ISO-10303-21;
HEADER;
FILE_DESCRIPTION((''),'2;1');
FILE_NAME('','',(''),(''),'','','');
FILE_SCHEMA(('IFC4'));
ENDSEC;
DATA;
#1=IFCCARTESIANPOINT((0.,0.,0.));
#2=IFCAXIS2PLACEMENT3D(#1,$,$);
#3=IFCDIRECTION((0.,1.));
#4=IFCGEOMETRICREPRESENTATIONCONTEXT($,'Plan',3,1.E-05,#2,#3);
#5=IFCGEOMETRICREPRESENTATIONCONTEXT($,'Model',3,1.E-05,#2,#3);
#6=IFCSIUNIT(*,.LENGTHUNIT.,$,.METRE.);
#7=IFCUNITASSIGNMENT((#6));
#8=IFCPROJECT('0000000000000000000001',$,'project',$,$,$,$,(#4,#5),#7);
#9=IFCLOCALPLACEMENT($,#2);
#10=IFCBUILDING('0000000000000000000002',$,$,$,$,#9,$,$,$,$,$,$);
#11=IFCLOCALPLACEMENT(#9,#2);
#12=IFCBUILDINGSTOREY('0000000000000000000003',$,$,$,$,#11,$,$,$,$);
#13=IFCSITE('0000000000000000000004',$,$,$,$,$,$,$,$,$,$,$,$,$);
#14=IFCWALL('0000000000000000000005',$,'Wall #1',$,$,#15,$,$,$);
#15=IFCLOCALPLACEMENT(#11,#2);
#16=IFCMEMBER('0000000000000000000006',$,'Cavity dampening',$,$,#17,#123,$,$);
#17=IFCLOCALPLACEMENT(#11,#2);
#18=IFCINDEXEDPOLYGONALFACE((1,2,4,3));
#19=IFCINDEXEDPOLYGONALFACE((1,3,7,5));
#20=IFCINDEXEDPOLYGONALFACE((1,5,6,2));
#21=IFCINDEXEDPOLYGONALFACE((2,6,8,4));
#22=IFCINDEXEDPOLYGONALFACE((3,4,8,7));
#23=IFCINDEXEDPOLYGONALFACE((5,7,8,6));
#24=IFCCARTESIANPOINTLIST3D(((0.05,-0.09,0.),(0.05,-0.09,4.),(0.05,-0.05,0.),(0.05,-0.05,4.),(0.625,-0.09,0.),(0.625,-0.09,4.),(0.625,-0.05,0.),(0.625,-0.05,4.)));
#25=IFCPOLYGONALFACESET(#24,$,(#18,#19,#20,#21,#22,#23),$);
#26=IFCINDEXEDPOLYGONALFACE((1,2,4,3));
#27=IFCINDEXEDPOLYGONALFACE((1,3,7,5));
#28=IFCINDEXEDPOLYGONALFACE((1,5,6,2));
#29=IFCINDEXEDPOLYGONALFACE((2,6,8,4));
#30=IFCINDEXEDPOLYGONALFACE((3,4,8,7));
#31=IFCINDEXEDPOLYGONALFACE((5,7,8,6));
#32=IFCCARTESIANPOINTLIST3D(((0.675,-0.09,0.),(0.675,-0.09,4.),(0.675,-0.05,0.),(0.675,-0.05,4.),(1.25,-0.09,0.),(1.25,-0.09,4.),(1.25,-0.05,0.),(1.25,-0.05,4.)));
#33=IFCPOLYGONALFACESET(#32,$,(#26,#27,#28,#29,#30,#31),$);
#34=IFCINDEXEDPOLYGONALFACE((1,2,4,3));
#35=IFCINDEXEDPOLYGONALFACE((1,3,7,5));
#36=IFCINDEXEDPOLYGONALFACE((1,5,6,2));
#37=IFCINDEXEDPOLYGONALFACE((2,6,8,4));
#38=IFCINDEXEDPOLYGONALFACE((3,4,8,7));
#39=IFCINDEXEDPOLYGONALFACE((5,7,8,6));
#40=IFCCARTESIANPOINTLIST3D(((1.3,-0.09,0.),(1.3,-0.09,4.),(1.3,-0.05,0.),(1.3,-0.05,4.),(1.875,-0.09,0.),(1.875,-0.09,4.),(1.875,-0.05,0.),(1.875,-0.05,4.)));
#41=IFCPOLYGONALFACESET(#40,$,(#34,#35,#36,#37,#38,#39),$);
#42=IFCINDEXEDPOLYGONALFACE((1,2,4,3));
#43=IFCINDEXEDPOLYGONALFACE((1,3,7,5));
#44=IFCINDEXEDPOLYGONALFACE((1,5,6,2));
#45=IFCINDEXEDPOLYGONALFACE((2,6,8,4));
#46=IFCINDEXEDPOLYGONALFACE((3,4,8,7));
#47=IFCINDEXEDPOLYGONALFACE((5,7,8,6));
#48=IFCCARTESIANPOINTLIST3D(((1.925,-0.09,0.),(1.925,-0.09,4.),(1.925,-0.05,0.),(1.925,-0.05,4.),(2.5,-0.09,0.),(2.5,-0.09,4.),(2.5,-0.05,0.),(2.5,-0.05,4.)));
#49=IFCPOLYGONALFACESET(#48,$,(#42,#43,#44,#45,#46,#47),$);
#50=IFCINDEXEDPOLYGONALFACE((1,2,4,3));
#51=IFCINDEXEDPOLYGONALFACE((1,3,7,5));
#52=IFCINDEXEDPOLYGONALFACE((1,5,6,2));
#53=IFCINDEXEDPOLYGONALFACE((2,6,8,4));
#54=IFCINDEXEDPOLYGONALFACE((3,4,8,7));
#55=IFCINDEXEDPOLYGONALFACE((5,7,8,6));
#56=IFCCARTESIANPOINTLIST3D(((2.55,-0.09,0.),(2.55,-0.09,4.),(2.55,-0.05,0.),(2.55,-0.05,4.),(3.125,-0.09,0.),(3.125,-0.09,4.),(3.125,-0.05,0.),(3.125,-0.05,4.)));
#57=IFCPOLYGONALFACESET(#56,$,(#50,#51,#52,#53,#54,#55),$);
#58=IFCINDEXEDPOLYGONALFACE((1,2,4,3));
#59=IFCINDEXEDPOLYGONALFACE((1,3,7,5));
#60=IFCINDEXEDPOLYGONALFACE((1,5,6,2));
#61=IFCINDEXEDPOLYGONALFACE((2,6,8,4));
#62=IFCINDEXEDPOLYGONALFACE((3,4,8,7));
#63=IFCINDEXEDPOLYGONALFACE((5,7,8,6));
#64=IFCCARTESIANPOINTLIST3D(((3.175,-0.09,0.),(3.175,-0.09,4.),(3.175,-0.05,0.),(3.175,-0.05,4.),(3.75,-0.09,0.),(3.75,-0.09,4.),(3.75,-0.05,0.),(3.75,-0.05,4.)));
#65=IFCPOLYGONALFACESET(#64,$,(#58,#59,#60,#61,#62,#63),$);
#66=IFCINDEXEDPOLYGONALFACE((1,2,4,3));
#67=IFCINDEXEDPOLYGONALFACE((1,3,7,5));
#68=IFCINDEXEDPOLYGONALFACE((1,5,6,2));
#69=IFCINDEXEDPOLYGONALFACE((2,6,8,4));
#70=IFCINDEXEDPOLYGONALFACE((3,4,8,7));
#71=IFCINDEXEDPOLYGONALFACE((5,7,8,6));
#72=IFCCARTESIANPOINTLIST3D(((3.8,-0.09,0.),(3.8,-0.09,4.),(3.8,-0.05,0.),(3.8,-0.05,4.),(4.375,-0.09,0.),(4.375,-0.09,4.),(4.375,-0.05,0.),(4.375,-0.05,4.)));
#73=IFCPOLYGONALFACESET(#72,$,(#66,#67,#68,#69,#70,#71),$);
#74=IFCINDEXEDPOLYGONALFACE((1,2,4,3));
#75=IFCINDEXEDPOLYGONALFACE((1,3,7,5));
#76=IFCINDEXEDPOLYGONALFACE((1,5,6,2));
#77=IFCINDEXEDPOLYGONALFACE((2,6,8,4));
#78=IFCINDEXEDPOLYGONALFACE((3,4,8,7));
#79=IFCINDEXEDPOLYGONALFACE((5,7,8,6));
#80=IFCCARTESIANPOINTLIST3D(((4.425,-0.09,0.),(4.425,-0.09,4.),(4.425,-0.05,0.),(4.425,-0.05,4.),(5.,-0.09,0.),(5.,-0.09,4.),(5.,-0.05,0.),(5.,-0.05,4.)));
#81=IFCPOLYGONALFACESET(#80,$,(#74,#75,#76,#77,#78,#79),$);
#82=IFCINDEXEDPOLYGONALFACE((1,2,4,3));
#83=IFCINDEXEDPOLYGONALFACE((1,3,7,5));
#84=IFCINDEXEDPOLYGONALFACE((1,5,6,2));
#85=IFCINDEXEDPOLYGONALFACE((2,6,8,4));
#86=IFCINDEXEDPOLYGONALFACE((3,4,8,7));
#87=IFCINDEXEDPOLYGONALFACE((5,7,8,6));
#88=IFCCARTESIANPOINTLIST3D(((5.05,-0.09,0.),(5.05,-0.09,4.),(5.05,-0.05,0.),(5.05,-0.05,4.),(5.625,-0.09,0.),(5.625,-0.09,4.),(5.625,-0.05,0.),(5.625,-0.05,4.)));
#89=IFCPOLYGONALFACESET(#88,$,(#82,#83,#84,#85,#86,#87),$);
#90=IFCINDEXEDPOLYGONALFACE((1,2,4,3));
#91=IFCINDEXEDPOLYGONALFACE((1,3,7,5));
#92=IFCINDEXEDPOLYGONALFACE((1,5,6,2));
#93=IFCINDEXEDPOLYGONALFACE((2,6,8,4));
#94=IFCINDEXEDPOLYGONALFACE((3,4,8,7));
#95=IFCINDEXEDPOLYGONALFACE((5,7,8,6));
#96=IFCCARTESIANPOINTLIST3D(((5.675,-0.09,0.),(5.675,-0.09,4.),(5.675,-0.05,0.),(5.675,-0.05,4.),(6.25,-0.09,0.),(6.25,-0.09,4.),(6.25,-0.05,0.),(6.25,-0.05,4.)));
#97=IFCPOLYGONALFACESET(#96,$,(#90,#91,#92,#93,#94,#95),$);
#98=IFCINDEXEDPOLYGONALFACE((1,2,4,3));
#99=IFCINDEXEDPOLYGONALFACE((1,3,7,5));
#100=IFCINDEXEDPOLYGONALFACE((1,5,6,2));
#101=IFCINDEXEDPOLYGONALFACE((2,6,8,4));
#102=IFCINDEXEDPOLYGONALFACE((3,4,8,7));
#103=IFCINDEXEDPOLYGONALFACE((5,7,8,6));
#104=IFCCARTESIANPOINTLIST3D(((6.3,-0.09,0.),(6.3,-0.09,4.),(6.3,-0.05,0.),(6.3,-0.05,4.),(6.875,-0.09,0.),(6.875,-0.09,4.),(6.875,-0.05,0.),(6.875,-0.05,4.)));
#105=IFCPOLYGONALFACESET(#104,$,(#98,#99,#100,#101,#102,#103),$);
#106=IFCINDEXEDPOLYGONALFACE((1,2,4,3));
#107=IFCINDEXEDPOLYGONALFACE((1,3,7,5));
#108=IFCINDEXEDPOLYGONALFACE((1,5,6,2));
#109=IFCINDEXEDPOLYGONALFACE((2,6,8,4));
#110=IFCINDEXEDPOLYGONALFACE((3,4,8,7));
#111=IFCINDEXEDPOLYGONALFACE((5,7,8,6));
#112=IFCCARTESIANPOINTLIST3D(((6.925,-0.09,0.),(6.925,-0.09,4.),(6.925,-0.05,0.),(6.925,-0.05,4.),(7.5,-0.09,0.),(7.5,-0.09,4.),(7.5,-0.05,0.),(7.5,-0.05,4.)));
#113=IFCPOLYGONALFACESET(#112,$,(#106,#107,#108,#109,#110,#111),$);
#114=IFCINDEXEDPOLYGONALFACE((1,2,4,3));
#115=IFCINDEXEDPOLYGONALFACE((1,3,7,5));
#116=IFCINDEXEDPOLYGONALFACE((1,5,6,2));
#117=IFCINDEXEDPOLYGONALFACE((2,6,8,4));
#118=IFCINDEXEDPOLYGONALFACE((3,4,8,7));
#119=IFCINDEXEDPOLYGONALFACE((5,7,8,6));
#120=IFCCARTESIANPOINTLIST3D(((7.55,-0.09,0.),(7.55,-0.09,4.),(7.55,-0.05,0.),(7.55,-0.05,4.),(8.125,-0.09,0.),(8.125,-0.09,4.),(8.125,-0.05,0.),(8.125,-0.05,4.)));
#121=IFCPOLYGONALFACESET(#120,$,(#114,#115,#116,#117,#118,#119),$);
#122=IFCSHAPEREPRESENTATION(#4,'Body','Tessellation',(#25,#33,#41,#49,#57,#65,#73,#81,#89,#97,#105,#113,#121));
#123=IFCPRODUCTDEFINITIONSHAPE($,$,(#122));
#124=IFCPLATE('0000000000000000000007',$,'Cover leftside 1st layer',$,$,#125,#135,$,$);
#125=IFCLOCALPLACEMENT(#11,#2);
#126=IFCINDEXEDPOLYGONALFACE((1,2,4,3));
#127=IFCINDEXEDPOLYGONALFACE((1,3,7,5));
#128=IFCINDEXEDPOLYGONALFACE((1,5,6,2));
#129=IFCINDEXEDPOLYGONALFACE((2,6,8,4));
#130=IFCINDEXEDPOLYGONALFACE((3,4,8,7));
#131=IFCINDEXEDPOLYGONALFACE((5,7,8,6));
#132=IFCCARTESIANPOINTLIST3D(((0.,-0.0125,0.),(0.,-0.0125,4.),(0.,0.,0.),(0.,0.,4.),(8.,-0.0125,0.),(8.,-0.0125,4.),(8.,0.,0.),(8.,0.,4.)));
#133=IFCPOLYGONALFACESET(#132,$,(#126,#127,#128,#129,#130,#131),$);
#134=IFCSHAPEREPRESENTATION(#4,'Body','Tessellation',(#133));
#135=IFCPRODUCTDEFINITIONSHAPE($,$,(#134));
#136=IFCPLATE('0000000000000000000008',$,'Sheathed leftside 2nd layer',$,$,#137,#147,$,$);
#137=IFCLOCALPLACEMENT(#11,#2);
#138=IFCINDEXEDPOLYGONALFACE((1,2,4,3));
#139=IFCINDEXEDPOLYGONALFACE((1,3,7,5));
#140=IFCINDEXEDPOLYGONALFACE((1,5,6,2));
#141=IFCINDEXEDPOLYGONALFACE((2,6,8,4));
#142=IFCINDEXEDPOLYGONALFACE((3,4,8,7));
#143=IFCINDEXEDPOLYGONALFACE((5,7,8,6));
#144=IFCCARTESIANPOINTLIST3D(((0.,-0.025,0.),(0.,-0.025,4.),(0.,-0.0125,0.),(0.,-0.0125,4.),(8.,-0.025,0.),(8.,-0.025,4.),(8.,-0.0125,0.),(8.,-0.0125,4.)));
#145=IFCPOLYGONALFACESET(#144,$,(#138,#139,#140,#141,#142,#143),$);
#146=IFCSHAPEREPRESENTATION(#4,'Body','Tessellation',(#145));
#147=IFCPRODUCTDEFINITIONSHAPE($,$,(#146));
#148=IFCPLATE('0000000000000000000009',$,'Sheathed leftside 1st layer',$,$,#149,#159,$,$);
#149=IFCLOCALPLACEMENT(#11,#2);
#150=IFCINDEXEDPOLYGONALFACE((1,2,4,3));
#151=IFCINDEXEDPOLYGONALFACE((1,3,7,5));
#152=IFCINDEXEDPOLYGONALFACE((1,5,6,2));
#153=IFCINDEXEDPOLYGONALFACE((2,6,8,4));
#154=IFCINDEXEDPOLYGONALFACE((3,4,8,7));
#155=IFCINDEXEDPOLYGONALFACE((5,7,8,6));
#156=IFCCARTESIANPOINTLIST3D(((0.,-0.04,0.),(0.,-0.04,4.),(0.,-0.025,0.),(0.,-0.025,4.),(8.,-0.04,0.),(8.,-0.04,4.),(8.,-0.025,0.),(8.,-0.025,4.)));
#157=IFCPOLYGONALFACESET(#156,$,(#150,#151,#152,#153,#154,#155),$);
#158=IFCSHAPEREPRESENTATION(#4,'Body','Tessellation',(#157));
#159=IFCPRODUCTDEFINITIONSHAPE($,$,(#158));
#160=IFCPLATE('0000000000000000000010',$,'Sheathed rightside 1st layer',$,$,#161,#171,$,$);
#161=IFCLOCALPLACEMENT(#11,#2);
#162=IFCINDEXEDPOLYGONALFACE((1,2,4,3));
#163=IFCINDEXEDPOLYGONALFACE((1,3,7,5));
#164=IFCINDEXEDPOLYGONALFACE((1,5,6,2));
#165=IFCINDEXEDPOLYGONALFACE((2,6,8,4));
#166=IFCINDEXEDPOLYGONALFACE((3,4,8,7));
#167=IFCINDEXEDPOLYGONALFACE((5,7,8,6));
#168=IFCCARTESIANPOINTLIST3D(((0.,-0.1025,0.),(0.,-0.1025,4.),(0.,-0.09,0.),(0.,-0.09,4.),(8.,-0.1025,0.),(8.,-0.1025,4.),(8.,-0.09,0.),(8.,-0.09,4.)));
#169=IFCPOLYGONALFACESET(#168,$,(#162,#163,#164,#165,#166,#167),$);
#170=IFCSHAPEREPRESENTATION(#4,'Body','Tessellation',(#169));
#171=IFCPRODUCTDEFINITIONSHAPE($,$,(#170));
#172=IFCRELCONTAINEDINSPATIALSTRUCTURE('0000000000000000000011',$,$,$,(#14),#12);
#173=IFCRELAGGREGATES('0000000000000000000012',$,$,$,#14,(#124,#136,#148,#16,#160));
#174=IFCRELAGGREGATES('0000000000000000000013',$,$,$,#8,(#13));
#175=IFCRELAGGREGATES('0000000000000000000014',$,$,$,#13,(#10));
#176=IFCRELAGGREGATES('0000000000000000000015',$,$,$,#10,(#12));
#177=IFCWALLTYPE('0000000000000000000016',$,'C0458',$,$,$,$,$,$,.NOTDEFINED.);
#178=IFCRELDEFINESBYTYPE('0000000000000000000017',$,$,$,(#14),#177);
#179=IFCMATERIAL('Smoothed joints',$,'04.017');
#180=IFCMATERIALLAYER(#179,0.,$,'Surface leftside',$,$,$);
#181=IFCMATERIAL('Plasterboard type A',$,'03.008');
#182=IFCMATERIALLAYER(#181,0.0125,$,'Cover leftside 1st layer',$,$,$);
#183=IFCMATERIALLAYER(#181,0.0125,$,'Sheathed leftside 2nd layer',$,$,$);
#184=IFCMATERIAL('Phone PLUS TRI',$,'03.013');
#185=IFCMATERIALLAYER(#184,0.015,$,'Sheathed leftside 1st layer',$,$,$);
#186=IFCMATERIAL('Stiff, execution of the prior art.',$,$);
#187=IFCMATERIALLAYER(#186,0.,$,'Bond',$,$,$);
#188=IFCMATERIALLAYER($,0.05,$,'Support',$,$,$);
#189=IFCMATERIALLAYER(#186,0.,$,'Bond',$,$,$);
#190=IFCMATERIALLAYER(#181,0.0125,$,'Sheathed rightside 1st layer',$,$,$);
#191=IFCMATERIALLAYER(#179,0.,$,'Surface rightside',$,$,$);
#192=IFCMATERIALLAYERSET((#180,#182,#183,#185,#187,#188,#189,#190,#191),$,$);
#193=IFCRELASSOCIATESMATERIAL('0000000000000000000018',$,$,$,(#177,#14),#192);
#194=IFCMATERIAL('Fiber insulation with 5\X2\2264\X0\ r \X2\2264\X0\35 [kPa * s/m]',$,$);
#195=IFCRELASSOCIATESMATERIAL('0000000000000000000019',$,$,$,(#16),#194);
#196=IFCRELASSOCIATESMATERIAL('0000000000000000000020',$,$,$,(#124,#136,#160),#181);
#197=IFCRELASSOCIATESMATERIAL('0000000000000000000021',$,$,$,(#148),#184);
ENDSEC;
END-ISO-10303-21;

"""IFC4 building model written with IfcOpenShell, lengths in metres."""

from ifc_helpers import new_model, si_unit, direction, frame, frame_2d, origin, origin_with_axes, place, context, project, spatial, rectangle, extrude, material, layer, layer_set, type_object, element, aggregate, save


model = new_model("IFC4")

# Units and contexts
plan_context = context("Plan", 3, precision=1e-05, world=origin(), true_north=direction((0.0, 1.0)))
model_context = context("Model", 3, precision=1e-05, world=origin(), true_north=direction((0.0, 1.0)))
ifc_project = project(units=[si_unit("LENGTHUNIT", "METRE")], contexts=[plan_context, model_context])

# Site, building, storey
site = spatial("IfcSite", under=ifc_project)
building_placement = place(None, origin())
building = spatial("IfcBuilding", under=site, at=building_placement)
storey_placement = place(building_placement, origin())
storey = spatial("IfcBuildingStorey", under=building, at=storey_placement)

# Wall, member, plates
ifc_material_1 = material(Name="Smoothed joints", Category="04.017")
ifc_layer_1 = layer(ifc_material_1, 0.0, Name="Surface leftside")
ifc_material_2 = material(Name="Plasterboard type A", Category="03.008")
ifc_layer_2 = layer(ifc_material_2, 0.0125, Name="Cover leftside 1st layer")
ifc_layer_3 = layer(ifc_material_2, 0.0125, Name="Sheathed leftside 2nd layer")
ifc_material_3 = material(Name="Phone PLUS TRI", Category="03.013")
ifc_layer_4 = layer(ifc_material_3, 0.015, Name="Sheathed leftside 1st layer")
ifc_material_4 = material(Name="Stiff, execution of the prior art.")
ifc_layer_5 = layer(ifc_material_4, 0.0, Name="Bond")
ifc_layer_6 = layer(None, 0.05, Name="Support")
ifc_layer_7 = layer(ifc_material_4, 0.0, Name="Bond")
ifc_layer_8 = layer(ifc_material_2, 0.0125, Name="Sheathed rightside 1st layer")
ifc_layer_9 = layer(ifc_material_1, 0.0, Name="Surface rightside")
ifc_layer_set = layer_set([ifc_layer_1, ifc_layer_2, ifc_layer_3, ifc_layer_4, ifc_layer_5, ifc_layer_6, ifc_layer_7, ifc_layer_8, ifc_layer_9])
wall_type = type_object("IfcWallType", Name="C0458", PredefinedType="NOTDEFINED", material=ifc_layer_set)
wall_placement = place(None, frame((0.0, 0.0, 0.0), z_axis=(0.0, -1.0, 0.0), x_axis=(1.0, 0.0, 0.0)))
wall = element("IfcWall", 1, at=wall_placement, inside=storey, type_object=wall_type, material=ifc_layer_set, Name="Wall #1")
ifc_material_5 = material(Name="Fiber insulation with 5≤ r ≤35 [kPa * s/m]")
member_1_placement = place(wall_placement, origin())
member_1 = element("IfcMember", 2, at=member_1_placement, material=ifc_material_5, Name="Cavity dampening", context=plan_context, shape_type="SweptSolid", body=[
    extrude(rectangle(XDim=0.575, YDim=0.04, at=frame_2d((0.2875, 0.02), x_axis=(1.0, 0.0))), frame((0.05, 4.0, 0.05), z_axis=(0.0, -1.0, 0.0), x_axis=(1.0, 0.0, 0.0)), (0.0, 0.0, 1.0), 4.0),
    extrude(rectangle(XDim=0.575, YDim=0.04, at=frame_2d((0.2875, 0.02), x_axis=(1.0, 0.0))), frame((0.675, 4.0, 0.05), z_axis=(0.0, -1.0, 0.0), x_axis=(1.0, 0.0, 0.0)), (0.0, 0.0, 1.0), 4.0),
    extrude(rectangle(XDim=0.575, YDim=0.04, at=frame_2d((0.2875, 0.02), x_axis=(1.0, 0.0))), frame((1.3, 4.0, 0.05), z_axis=(0.0, -1.0, 0.0), x_axis=(1.0, 0.0, 0.0)), (0.0, 0.0, 1.0), 4.0),
    extrude(rectangle(XDim=0.575, YDim=0.04, at=frame_2d((0.2875, 0.02), x_axis=(1.0, 0.0))), frame((1.925, 4.0, 0.05), z_axis=(0.0, -1.0, 0.0), x_axis=(1.0, 0.0, 0.0)), (0.0, 0.0, 1.0), 4.0),
    extrude(rectangle(XDim=0.575, YDim=0.04, at=frame_2d((0.2875, 0.02), x_axis=(1.0, 0.0))), frame((2.55, 4.0, 0.05), z_axis=(0.0, -1.0, 0.0), x_axis=(1.0, 0.0, 0.0)), (0.0, 0.0, 1.0), 4.0),
    extrude(rectangle(XDim=0.575, YDim=0.04, at=frame_2d((0.2875, 0.02), x_axis=(1.0, 0.0))), frame((3.175, 4.0, 0.05), z_axis=(0.0, -1.0, 0.0), x_axis=(1.0, 0.0, 0.0)), (0.0, 0.0, 1.0), 4.0),
    extrude(rectangle(XDim=0.575, YDim=0.04, at=frame_2d((0.2875, 0.02), x_axis=(1.0, 0.0))), frame((3.8, 4.0, 0.05), z_axis=(0.0, -1.0, 0.0), x_axis=(1.0, 0.0, 0.0)), (0.0, 0.0, 1.0), 4.0),
    extrude(rectangle(XDim=0.575, YDim=0.04, at=frame_2d((0.2875, 0.02), x_axis=(1.0, 0.0))), frame((4.425, 4.0, 0.05), z_axis=(0.0, -1.0, 0.0), x_axis=(1.0, 0.0, 0.0)), (0.0, 0.0, 1.0), 4.0),
    extrude(rectangle(XDim=0.575, YDim=0.04, at=frame_2d((0.2875, 0.02), x_axis=(1.0, 0.0))), frame((5.05, 4.0, 0.05), z_axis=(0.0, -1.0, 0.0), x_axis=(1.0, 0.0, 0.0)), (0.0, 0.0, 1.0), 4.0),
    extrude(rectangle(XDim=0.575, YDim=0.04, at=frame_2d((0.2875, 0.02), x_axis=(1.0, 0.0))), frame((5.675, 4.0, 0.05), z_axis=(0.0, -1.0, 0.0), x_axis=(1.0, 0.0, 0.0)), (0.0, 0.0, 1.0), 4.0),
    extrude(rectangle(XDim=0.575, YDim=0.04, at=frame_2d((0.2875, 0.02), x_axis=(1.0, 0.0))), frame((6.3, 4.0, 0.05), z_axis=(0.0, -1.0, 0.0), x_axis=(1.0, 0.0, 0.0)), (0.0, 0.0, 1.0), 4.0),
    extrude(rectangle(XDim=0.575, YDim=0.04, at=frame_2d((0.2875, 0.02), x_axis=(1.0, 0.0))), frame((6.925, 4.0, 0.05), z_axis=(0.0, -1.0, 0.0), x_axis=(1.0, 0.0, 0.0)), (0.0, 0.0, 1.0), 4.0),
    extrude(rectangle(XDim=0.575, YDim=0.04, at=frame_2d((0.2875, 0.02), x_axis=(1.0, 0.0))), frame((7.55, 4.0, 0.05), z_axis=(0.0, -1.0, 0.0), x_axis=(1.0, 0.0, 0.0)), (0.0, 0.0, 1.0), 4.0),
])
plate_1_placement = place(wall_placement, origin())
plate_1 = element("IfcPlate", 3, at=plate_1_placement, material=ifc_material_2, Name="Cover leftside 1st layer", context=plan_context, shape_type="SweptSolid", body=[
    extrude(rectangle(XDim=8.0, YDim=4.0, at=frame_2d((4.0, 2.0), x_axis=(1.0, 0.0))), origin_with_axes(), (0.0, 0.0, 1.0), 0.0125),
])
plate_2_placement = place(wall_placement, origin())
plate_2 = element("IfcPlate", 4, at=plate_2_placement, material=ifc_material_2, Name="Sheathed leftside 2nd layer", context=plan_context, shape_type="SweptSolid", body=[
    extrude(rectangle(XDim=8.0, YDim=4.0, at=frame_2d((4.0, 2.0), x_axis=(1.0, 0.0))), frame((0.0, 0.0, 0.0125), z_axis=(0.0, 0.0, 1.0), x_axis=(1.0, 0.0, 0.0)), (0.0, 0.0, 1.0), 0.0125),
])
plate_3_placement = place(wall_placement, origin())
plate_3 = element("IfcPlate", 5, at=plate_3_placement, material=ifc_material_3, Name="Sheathed leftside 1st layer", context=plan_context, shape_type="SweptSolid", body=[
    extrude(rectangle(XDim=8.0, YDim=4.0, at=frame_2d((4.0, 2.0), x_axis=(1.0, 0.0))), frame((0.0, 0.0, 0.025), z_axis=(0.0, 0.0, 1.0), x_axis=(1.0, 0.0, 0.0)), (0.0, 0.0, 1.0), 0.015),
])
plate_4_placement = place(wall_placement, origin())
plate_4 = element("IfcPlate", 6, at=plate_4_placement, material=ifc_material_2, Name="Sheathed rightside 1st layer", context=plan_context, shape_type="SweptSolid", body=[
    extrude(rectangle(XDim=8.0, YDim=4.0, at=frame_2d((4.0, 2.0), x_axis=(1.0, 0.0))), frame((0.0, 0.0, 0.09), z_axis=(0.0, 0.0, 1.0), x_axis=(1.0, 0.0, 0.0)), (0.0, 0.0, 1.0), 0.0125),
])
aggregate(wall, [plate_1, plate_2, plate_3, member_1, plate_4])

save(model, "model.ifc")
